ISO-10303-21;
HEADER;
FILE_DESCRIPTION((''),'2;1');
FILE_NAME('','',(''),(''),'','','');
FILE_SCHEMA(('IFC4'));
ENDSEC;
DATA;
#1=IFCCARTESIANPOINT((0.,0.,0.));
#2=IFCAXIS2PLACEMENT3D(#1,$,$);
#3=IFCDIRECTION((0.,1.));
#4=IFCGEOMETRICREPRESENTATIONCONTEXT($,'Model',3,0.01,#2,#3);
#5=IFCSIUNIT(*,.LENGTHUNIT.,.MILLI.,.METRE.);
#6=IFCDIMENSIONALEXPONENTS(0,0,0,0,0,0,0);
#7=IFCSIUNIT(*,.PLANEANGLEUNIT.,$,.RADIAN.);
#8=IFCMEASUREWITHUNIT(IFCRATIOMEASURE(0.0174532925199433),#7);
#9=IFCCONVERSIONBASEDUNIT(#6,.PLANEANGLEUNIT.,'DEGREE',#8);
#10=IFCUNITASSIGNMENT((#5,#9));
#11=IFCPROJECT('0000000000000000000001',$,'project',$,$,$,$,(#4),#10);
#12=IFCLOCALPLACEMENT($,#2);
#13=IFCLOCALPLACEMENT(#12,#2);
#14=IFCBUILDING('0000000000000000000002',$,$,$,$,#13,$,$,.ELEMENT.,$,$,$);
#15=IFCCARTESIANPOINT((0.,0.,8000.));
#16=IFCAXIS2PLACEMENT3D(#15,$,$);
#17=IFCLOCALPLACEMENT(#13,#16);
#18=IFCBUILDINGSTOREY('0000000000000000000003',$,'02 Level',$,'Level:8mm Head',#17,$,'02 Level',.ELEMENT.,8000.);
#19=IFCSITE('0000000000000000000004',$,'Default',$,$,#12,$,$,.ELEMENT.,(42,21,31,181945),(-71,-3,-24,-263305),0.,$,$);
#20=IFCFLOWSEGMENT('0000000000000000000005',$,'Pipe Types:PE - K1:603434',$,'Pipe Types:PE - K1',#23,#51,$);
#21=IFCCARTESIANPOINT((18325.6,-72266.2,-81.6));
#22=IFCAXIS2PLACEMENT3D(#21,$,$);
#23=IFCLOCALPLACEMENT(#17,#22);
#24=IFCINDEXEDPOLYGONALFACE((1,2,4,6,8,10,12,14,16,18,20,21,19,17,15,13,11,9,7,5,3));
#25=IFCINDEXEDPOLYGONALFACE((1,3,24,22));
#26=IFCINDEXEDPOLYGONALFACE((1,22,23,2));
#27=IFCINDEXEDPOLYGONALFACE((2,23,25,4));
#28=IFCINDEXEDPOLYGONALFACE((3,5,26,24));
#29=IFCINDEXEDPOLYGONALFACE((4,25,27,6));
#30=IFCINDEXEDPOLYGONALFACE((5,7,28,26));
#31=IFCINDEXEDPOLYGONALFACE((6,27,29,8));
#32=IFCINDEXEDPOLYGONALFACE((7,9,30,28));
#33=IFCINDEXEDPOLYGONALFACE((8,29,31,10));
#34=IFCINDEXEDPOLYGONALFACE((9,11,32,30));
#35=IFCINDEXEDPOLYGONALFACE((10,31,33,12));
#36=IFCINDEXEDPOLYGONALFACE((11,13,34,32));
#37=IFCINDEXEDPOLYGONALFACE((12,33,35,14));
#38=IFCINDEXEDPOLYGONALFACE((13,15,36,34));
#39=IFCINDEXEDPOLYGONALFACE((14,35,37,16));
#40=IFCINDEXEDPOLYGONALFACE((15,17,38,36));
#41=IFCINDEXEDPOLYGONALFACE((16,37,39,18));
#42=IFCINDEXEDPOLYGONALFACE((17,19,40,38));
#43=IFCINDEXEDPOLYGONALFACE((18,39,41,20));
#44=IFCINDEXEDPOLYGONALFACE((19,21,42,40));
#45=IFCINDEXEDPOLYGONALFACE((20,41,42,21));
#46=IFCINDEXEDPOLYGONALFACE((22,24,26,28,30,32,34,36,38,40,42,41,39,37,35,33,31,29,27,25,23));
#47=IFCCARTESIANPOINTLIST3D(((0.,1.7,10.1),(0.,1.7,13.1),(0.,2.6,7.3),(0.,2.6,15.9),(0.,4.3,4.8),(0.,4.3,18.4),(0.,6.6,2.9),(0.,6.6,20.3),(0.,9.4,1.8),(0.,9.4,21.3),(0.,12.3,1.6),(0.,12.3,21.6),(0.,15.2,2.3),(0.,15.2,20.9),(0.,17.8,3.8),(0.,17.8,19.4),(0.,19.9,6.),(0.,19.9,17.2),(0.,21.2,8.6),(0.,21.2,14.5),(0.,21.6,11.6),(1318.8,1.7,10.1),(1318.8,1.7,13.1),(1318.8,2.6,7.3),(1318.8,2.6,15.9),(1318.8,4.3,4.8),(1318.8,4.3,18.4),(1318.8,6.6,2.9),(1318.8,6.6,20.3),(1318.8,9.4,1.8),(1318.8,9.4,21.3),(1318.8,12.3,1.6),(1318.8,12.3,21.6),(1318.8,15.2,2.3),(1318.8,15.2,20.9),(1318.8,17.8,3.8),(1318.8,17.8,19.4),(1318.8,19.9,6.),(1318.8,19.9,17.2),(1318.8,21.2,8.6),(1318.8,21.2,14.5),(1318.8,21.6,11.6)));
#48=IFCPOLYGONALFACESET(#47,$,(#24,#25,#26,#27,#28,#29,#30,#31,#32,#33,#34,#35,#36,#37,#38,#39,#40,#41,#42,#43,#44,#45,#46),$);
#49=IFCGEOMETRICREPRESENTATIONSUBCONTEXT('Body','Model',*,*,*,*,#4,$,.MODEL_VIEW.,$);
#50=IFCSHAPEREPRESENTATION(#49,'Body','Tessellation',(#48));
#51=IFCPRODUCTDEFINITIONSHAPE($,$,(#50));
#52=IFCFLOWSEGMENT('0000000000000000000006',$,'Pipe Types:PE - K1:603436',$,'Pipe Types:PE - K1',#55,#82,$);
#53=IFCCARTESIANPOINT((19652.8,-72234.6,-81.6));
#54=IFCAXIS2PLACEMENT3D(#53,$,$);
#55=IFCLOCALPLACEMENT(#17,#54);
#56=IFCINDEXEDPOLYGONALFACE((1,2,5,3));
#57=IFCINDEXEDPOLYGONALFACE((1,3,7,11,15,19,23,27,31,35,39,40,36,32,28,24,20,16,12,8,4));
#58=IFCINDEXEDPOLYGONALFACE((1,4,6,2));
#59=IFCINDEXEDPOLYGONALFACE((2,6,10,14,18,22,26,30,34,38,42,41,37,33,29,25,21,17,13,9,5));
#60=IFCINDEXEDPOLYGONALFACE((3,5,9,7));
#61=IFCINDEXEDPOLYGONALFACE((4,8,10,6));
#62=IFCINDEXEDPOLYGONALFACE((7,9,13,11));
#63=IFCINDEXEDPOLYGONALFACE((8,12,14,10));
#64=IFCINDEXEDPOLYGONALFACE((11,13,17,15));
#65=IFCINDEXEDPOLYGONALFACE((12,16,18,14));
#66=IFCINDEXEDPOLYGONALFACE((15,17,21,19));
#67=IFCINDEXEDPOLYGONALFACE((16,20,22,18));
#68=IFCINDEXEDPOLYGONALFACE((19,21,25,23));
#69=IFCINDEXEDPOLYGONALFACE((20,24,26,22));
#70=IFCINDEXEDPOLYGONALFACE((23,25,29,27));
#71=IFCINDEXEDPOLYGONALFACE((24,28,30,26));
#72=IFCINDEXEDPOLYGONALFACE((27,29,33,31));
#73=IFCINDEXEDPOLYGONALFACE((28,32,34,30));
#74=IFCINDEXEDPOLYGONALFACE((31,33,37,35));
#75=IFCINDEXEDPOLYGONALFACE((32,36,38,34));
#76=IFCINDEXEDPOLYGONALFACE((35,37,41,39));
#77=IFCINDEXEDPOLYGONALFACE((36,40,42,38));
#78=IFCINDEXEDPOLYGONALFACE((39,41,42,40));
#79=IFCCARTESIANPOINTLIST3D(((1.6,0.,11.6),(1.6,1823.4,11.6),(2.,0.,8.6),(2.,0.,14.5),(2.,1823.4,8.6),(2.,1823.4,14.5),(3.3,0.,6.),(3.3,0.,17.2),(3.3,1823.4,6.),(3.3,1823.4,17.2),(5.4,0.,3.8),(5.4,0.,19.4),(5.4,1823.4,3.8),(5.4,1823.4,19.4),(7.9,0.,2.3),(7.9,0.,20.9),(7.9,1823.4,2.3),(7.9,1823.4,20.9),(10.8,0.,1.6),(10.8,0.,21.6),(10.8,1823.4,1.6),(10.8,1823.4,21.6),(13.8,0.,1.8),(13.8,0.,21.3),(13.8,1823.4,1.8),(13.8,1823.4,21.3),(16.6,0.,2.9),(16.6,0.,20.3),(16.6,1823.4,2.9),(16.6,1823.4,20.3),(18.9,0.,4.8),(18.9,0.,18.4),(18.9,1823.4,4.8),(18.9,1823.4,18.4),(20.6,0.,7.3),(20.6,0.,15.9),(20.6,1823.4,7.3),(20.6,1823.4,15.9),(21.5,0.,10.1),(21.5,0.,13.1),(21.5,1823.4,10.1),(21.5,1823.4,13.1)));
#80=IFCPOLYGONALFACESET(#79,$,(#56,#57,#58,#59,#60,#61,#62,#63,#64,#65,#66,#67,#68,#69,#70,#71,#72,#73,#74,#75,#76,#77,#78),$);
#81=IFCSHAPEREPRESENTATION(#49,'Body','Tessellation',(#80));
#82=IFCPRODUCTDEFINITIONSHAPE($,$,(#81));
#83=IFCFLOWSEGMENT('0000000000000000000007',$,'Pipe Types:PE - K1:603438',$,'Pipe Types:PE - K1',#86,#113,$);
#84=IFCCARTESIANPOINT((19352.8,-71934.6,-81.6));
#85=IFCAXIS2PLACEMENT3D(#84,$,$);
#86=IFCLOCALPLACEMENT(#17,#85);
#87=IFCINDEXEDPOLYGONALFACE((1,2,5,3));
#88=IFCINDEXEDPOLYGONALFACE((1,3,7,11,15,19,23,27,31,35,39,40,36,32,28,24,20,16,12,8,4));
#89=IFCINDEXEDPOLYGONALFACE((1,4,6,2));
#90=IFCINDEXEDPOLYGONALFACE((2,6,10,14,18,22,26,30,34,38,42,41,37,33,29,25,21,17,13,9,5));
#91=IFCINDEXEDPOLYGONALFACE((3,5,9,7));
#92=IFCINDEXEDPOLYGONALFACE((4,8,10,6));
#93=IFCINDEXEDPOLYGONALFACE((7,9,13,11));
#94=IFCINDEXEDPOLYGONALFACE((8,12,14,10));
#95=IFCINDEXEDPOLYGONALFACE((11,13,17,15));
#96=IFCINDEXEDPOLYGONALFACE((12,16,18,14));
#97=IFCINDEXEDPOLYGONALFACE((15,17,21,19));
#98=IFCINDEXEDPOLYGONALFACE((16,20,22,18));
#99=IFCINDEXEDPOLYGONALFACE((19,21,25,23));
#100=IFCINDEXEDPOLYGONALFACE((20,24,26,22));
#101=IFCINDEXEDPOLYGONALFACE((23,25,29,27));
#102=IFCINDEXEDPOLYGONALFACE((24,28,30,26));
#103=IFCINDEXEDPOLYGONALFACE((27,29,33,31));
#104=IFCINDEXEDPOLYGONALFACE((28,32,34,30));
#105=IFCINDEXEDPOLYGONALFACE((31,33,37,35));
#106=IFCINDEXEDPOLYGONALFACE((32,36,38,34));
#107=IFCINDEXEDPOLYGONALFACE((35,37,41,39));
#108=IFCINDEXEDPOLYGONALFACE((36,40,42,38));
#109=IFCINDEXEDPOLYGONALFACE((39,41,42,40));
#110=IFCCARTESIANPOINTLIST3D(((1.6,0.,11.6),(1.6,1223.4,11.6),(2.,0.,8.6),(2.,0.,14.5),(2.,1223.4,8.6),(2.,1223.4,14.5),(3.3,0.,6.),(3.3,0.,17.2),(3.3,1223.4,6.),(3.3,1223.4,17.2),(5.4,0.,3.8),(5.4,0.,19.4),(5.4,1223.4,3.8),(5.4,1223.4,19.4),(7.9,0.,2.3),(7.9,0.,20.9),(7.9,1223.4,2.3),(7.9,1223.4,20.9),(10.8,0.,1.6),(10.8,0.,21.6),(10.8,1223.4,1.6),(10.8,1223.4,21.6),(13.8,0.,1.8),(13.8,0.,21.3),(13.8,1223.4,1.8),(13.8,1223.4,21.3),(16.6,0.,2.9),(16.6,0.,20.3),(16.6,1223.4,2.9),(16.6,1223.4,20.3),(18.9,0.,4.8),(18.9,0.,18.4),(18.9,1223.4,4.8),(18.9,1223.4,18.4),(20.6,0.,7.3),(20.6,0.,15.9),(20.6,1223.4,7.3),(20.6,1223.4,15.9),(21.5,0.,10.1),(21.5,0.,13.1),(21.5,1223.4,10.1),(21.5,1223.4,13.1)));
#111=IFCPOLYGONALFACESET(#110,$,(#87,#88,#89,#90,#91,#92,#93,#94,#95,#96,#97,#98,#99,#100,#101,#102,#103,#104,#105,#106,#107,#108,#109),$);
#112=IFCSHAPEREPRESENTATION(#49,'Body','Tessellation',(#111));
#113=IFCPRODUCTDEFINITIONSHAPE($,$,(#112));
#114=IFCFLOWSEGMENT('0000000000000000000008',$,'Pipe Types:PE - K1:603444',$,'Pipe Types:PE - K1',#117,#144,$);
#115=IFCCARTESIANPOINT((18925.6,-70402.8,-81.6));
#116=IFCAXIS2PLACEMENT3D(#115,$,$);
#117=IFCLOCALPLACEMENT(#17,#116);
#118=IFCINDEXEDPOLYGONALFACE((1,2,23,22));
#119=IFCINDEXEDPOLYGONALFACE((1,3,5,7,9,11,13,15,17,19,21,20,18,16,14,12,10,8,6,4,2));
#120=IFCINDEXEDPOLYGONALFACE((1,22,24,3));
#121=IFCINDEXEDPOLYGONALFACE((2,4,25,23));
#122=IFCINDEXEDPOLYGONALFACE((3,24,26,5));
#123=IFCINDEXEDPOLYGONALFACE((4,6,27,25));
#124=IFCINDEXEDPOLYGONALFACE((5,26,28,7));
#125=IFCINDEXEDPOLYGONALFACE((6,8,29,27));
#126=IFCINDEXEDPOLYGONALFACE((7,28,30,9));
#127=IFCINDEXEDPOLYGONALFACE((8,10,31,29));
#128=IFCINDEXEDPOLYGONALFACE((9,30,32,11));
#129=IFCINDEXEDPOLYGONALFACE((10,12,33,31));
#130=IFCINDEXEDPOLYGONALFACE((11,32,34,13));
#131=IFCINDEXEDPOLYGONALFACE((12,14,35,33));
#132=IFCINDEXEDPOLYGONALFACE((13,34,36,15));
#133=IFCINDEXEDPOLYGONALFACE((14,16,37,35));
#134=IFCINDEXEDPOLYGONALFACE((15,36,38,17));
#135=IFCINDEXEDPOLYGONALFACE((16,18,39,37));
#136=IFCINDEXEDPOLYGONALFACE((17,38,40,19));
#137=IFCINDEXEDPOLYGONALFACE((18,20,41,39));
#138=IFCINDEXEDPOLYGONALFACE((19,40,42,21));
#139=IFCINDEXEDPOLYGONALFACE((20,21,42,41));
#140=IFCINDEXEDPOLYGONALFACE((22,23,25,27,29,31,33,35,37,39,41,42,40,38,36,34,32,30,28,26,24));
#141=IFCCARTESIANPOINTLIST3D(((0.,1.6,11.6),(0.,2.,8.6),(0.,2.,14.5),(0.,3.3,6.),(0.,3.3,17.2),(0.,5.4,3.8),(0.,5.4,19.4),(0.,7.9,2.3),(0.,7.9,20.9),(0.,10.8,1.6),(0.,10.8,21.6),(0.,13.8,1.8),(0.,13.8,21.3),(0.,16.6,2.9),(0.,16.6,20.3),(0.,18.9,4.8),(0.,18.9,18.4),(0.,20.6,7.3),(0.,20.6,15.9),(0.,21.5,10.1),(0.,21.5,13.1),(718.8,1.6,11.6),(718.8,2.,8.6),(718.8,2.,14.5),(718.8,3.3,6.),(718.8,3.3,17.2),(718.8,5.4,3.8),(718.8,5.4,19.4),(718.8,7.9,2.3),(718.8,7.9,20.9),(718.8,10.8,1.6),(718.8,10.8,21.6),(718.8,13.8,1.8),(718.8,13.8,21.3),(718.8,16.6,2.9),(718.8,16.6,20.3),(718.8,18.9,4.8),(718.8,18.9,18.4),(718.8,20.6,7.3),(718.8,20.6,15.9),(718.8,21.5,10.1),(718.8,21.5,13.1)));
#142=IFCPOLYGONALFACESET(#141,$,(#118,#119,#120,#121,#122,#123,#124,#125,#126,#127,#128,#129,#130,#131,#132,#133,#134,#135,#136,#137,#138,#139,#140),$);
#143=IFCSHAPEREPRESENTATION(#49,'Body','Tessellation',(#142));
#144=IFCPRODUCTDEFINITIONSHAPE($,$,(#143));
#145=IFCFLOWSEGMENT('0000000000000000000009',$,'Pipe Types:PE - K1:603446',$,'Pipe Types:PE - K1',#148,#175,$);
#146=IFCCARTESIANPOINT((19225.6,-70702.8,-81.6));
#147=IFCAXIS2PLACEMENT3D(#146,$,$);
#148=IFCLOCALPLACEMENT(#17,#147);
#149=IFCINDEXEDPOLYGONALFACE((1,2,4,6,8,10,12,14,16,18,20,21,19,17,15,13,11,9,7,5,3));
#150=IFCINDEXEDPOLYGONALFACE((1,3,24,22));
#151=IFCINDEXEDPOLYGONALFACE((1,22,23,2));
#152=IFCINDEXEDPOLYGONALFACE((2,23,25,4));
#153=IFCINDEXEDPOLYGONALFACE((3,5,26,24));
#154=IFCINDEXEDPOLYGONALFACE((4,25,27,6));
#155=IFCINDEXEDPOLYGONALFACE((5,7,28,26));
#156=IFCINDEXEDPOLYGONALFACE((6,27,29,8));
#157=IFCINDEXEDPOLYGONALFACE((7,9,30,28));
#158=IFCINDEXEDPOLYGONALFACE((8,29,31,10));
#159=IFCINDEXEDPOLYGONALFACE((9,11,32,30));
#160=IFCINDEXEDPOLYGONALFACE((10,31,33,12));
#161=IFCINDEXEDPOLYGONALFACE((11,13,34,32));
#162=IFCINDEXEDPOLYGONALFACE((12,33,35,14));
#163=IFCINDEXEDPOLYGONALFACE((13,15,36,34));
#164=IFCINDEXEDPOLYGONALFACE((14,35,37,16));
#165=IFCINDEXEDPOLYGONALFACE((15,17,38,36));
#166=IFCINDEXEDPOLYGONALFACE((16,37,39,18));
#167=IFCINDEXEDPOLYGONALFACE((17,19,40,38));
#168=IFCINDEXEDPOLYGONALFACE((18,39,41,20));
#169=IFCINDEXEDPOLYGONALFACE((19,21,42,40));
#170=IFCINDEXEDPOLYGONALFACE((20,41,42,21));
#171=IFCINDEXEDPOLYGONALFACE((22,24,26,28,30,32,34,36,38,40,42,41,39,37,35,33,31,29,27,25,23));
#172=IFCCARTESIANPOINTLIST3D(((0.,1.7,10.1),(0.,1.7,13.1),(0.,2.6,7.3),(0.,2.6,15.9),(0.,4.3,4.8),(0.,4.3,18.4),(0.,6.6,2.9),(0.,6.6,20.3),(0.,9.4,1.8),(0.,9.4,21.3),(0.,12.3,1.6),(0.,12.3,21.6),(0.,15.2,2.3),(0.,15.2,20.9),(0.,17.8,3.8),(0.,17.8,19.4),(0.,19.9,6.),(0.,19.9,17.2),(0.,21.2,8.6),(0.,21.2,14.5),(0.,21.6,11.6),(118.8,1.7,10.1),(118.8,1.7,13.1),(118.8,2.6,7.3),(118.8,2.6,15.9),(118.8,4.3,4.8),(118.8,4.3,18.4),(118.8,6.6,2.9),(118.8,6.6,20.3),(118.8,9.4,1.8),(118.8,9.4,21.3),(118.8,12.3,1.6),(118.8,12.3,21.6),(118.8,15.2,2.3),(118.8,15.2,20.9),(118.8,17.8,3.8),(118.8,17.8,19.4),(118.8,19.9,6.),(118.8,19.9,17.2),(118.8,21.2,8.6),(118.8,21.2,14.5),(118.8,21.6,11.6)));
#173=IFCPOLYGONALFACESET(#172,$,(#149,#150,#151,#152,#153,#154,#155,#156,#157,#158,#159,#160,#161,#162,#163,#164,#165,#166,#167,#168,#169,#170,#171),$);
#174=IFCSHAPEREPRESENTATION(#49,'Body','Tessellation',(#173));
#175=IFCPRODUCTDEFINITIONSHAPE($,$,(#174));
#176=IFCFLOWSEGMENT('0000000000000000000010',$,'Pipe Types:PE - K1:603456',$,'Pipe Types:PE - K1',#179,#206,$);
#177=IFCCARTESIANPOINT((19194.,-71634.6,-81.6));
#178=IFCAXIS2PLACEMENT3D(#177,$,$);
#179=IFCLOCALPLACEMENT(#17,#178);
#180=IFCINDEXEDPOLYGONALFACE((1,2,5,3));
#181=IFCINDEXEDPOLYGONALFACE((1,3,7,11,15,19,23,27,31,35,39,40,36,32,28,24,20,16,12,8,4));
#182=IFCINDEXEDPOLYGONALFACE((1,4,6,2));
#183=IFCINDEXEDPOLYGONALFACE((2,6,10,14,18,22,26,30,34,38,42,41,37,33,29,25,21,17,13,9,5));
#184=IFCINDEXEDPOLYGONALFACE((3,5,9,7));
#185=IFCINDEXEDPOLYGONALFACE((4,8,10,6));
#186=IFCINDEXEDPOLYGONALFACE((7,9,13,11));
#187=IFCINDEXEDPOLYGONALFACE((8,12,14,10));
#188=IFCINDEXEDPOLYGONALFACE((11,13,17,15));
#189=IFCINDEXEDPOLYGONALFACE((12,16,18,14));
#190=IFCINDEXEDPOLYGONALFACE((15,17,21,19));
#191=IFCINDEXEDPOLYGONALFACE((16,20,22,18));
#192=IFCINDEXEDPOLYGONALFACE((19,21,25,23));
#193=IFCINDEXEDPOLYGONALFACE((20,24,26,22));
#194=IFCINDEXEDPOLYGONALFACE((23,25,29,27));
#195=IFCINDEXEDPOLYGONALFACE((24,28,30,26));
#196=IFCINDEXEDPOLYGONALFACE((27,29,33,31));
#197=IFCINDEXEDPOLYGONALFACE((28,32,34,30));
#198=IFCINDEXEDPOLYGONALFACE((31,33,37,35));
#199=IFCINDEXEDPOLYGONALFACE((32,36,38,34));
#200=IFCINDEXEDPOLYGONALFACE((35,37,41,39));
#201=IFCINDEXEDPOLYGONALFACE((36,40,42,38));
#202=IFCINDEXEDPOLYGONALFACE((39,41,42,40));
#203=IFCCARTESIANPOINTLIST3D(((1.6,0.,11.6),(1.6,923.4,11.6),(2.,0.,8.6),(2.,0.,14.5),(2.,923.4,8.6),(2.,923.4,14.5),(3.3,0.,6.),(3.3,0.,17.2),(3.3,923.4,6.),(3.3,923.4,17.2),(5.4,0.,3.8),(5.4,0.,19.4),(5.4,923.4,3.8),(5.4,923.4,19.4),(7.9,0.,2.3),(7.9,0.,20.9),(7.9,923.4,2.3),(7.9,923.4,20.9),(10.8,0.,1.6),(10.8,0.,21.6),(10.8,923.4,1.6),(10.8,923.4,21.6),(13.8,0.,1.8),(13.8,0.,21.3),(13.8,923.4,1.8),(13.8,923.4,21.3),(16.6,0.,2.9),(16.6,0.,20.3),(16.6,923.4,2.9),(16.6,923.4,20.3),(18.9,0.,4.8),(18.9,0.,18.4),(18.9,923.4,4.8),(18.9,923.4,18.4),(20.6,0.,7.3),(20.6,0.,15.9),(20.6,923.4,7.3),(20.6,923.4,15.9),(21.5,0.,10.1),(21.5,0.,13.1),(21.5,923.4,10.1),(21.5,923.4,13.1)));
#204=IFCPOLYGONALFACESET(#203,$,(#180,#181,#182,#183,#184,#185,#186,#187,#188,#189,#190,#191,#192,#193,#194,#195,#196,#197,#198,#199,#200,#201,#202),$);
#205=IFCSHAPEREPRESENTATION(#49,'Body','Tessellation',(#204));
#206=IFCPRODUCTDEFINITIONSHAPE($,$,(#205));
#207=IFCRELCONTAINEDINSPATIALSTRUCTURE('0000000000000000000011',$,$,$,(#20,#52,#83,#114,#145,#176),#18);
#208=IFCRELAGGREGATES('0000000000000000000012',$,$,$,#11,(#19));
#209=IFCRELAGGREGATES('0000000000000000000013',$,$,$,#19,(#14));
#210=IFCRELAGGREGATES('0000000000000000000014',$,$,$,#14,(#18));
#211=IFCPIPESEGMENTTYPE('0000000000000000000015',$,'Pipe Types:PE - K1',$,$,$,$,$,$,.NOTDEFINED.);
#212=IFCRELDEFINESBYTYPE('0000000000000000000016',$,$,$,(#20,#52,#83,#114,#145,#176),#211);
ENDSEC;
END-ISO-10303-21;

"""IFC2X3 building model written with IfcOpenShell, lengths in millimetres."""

from ifc_helpers import new_model, entity, si_unit, converted_unit, direction, frame, frame_2d, origin, origin_2d_with_axis, place, context, subcontext, project, spatial, circle, extrude, type_object, element, save


model = new_model("IFC2X3")

# Units and contexts
model_context = context("Model", 3, precision=0.01, world=origin(), true_north=direction((0.0, 1.0)))
body_context = subcontext(model_context, "Body", "Model", "MODEL_VIEW")
ifc_project = project(units=[si_unit("LENGTHUNIT", "METRE", prefix="MILLI"), converted_unit("PLANEANGLEUNIT", "DEGREE", entity("IfcRatioMeasure", 0.0174532925199433), si_unit("PLANEANGLEUNIT", "RADIAN"), dimensions=[0, 0, 0, 0, 0, 0, 0])], contexts=[model_context])

# Site, building, storey
site_placement = place(None, origin())
site = spatial("IfcSite", under=ifc_project, at=site_placement, Name="Default", CompositionType="ELEMENT", RefLatitude=(42, 21, 31, 181945), RefLongitude=(-71, -3, -24, -263305), RefElevation=0.0)
building_placement = place(site_placement, origin())
building = spatial("IfcBuilding", under=site, at=building_placement, CompositionType="ELEMENT")
storey_placement = place(building_placement, frame((0.0, 0.0, 8000.0)))
storey = spatial("IfcBuildingStorey", under=building, at=storey_placement, Name="02 Level", ObjectType="Level:8mm Head", LongName="02 Level", CompositionType="ELEMENT", Elevation=8000.0)

# Flow segments
pipe_segment_type = type_object("IfcPipeSegmentType", Name="Pipe Types:PE - K1", PredefinedType="NOTDEFINED")
flow_segment_1_placement = place(storey_placement, frame((18325.6, -72266.2, -81.6)))
element("IfcFlowSegment", 1, at=flow_segment_1_placement, inside=storey, type_object=pipe_segment_type, Name="Pipe Types:PE - K1:603434", ObjectType="Pipe Types:PE - K1", context=body_context, shape_type="SweptSolid", body=[
    extrude(circle(Radius=10.0, at=frame_2d((0.0, 0.0), x_axis=(1.0, 0.0))), frame((0.0, 11.6, 11.6), z_axis=(1.0, 0.0, 0.0), x_axis=(0.0, 1.0, 0.0)), (0.0, 0.0, 1.0), 1318.8),
])
flow_segment_2_placement = place(storey_placement, frame((19652.8, -72234.6, -81.6)))
element("IfcFlowSegment", 2, at=flow_segment_2_placement, inside=storey, type_object=pipe_segment_type, Name="Pipe Types:PE - K1:603436", ObjectType="Pipe Types:PE - K1", context=body_context, shape_type="SweptSolid", body=[
    extrude(circle(Radius=10.0, at=frame_2d((0.0, 0.0), x_axis=(1.0, 0.0))), frame((11.6, 0.0, 11.6), z_axis=(0.0, 1.0, 0.0), x_axis=(-1.0, 0.0, 0.0)), (0.0, 0.0, 1.0), 1823.4),
])
flow_segment_3_placement = place(storey_placement, frame((19352.8, -71934.6, -81.6)))
element("IfcFlowSegment", 3, at=flow_segment_3_placement, inside=storey, type_object=pipe_segment_type, Name="Pipe Types:PE - K1:603438", ObjectType="Pipe Types:PE - K1", context=body_context, shape_type="SweptSolid", body=[
    extrude(circle(Radius=10.0, at=frame_2d((0.0, 0.0), x_axis=(1.0, 0.0))), frame((11.6, 0.0, 11.6), z_axis=(0.0, 1.0, 0.0), x_axis=(-1.0, 0.0, 0.0)), (0.0, 0.0, 1.0), 1223.4),
])
flow_segment_4_placement = place(storey_placement, frame((18925.6, -70402.8, -81.6)))
element("IfcFlowSegment", 4, at=flow_segment_4_placement, inside=storey, type_object=pipe_segment_type, Name="Pipe Types:PE - K1:603444", ObjectType="Pipe Types:PE - K1", context=body_context, shape_type="SweptSolid", body=[
    extrude(circle(Radius=10.0, at=origin_2d_with_axis()), frame((0.0, 11.6, 11.6), z_axis=(1.0, 0.0, 0.0), x_axis=(0.0, -1.0, 0.0)), (0.0, 0.0, 1.0), 718.8),
])
flow_segment_5_placement = place(storey_placement, frame((19225.6, -70702.8, -81.6)))
element("IfcFlowSegment", 5, at=flow_segment_5_placement, inside=storey, type_object=pipe_segment_type, Name="Pipe Types:PE - K1:603446", ObjectType="Pipe Types:PE - K1", context=body_context, shape_type="SweptSolid", body=[
    extrude(circle(Radius=10.0, at=frame_2d((0.0, 0.0), x_axis=(1.0, 0.0))), frame((0.0, 11.6, 11.6), z_axis=(1.0, 0.0, 0.0), x_axis=(0.0, 1.0, 0.0)), (0.0, 0.0, 1.0), 118.8),
])
flow_segment_6_placement = place(storey_placement, frame((19194.0, -71634.6, -81.6)))
element("IfcFlowSegment", 6, at=flow_segment_6_placement, inside=storey, type_object=pipe_segment_type, Name="Pipe Types:PE - K1:603456", ObjectType="Pipe Types:PE - K1", context=body_context, shape_type="SweptSolid", body=[
    extrude(circle(Radius=10.0, at=frame_2d((0.0, 0.0), x_axis=(1.0, 0.0))), frame((11.6, 0.0, 11.6), z_axis=(0.0, 1.0, 0.0), x_axis=(-1.0, 0.0, 0.0)), (0.0, 0.0, 1.0), 923.4),
])

save(model, "model.ifc")
